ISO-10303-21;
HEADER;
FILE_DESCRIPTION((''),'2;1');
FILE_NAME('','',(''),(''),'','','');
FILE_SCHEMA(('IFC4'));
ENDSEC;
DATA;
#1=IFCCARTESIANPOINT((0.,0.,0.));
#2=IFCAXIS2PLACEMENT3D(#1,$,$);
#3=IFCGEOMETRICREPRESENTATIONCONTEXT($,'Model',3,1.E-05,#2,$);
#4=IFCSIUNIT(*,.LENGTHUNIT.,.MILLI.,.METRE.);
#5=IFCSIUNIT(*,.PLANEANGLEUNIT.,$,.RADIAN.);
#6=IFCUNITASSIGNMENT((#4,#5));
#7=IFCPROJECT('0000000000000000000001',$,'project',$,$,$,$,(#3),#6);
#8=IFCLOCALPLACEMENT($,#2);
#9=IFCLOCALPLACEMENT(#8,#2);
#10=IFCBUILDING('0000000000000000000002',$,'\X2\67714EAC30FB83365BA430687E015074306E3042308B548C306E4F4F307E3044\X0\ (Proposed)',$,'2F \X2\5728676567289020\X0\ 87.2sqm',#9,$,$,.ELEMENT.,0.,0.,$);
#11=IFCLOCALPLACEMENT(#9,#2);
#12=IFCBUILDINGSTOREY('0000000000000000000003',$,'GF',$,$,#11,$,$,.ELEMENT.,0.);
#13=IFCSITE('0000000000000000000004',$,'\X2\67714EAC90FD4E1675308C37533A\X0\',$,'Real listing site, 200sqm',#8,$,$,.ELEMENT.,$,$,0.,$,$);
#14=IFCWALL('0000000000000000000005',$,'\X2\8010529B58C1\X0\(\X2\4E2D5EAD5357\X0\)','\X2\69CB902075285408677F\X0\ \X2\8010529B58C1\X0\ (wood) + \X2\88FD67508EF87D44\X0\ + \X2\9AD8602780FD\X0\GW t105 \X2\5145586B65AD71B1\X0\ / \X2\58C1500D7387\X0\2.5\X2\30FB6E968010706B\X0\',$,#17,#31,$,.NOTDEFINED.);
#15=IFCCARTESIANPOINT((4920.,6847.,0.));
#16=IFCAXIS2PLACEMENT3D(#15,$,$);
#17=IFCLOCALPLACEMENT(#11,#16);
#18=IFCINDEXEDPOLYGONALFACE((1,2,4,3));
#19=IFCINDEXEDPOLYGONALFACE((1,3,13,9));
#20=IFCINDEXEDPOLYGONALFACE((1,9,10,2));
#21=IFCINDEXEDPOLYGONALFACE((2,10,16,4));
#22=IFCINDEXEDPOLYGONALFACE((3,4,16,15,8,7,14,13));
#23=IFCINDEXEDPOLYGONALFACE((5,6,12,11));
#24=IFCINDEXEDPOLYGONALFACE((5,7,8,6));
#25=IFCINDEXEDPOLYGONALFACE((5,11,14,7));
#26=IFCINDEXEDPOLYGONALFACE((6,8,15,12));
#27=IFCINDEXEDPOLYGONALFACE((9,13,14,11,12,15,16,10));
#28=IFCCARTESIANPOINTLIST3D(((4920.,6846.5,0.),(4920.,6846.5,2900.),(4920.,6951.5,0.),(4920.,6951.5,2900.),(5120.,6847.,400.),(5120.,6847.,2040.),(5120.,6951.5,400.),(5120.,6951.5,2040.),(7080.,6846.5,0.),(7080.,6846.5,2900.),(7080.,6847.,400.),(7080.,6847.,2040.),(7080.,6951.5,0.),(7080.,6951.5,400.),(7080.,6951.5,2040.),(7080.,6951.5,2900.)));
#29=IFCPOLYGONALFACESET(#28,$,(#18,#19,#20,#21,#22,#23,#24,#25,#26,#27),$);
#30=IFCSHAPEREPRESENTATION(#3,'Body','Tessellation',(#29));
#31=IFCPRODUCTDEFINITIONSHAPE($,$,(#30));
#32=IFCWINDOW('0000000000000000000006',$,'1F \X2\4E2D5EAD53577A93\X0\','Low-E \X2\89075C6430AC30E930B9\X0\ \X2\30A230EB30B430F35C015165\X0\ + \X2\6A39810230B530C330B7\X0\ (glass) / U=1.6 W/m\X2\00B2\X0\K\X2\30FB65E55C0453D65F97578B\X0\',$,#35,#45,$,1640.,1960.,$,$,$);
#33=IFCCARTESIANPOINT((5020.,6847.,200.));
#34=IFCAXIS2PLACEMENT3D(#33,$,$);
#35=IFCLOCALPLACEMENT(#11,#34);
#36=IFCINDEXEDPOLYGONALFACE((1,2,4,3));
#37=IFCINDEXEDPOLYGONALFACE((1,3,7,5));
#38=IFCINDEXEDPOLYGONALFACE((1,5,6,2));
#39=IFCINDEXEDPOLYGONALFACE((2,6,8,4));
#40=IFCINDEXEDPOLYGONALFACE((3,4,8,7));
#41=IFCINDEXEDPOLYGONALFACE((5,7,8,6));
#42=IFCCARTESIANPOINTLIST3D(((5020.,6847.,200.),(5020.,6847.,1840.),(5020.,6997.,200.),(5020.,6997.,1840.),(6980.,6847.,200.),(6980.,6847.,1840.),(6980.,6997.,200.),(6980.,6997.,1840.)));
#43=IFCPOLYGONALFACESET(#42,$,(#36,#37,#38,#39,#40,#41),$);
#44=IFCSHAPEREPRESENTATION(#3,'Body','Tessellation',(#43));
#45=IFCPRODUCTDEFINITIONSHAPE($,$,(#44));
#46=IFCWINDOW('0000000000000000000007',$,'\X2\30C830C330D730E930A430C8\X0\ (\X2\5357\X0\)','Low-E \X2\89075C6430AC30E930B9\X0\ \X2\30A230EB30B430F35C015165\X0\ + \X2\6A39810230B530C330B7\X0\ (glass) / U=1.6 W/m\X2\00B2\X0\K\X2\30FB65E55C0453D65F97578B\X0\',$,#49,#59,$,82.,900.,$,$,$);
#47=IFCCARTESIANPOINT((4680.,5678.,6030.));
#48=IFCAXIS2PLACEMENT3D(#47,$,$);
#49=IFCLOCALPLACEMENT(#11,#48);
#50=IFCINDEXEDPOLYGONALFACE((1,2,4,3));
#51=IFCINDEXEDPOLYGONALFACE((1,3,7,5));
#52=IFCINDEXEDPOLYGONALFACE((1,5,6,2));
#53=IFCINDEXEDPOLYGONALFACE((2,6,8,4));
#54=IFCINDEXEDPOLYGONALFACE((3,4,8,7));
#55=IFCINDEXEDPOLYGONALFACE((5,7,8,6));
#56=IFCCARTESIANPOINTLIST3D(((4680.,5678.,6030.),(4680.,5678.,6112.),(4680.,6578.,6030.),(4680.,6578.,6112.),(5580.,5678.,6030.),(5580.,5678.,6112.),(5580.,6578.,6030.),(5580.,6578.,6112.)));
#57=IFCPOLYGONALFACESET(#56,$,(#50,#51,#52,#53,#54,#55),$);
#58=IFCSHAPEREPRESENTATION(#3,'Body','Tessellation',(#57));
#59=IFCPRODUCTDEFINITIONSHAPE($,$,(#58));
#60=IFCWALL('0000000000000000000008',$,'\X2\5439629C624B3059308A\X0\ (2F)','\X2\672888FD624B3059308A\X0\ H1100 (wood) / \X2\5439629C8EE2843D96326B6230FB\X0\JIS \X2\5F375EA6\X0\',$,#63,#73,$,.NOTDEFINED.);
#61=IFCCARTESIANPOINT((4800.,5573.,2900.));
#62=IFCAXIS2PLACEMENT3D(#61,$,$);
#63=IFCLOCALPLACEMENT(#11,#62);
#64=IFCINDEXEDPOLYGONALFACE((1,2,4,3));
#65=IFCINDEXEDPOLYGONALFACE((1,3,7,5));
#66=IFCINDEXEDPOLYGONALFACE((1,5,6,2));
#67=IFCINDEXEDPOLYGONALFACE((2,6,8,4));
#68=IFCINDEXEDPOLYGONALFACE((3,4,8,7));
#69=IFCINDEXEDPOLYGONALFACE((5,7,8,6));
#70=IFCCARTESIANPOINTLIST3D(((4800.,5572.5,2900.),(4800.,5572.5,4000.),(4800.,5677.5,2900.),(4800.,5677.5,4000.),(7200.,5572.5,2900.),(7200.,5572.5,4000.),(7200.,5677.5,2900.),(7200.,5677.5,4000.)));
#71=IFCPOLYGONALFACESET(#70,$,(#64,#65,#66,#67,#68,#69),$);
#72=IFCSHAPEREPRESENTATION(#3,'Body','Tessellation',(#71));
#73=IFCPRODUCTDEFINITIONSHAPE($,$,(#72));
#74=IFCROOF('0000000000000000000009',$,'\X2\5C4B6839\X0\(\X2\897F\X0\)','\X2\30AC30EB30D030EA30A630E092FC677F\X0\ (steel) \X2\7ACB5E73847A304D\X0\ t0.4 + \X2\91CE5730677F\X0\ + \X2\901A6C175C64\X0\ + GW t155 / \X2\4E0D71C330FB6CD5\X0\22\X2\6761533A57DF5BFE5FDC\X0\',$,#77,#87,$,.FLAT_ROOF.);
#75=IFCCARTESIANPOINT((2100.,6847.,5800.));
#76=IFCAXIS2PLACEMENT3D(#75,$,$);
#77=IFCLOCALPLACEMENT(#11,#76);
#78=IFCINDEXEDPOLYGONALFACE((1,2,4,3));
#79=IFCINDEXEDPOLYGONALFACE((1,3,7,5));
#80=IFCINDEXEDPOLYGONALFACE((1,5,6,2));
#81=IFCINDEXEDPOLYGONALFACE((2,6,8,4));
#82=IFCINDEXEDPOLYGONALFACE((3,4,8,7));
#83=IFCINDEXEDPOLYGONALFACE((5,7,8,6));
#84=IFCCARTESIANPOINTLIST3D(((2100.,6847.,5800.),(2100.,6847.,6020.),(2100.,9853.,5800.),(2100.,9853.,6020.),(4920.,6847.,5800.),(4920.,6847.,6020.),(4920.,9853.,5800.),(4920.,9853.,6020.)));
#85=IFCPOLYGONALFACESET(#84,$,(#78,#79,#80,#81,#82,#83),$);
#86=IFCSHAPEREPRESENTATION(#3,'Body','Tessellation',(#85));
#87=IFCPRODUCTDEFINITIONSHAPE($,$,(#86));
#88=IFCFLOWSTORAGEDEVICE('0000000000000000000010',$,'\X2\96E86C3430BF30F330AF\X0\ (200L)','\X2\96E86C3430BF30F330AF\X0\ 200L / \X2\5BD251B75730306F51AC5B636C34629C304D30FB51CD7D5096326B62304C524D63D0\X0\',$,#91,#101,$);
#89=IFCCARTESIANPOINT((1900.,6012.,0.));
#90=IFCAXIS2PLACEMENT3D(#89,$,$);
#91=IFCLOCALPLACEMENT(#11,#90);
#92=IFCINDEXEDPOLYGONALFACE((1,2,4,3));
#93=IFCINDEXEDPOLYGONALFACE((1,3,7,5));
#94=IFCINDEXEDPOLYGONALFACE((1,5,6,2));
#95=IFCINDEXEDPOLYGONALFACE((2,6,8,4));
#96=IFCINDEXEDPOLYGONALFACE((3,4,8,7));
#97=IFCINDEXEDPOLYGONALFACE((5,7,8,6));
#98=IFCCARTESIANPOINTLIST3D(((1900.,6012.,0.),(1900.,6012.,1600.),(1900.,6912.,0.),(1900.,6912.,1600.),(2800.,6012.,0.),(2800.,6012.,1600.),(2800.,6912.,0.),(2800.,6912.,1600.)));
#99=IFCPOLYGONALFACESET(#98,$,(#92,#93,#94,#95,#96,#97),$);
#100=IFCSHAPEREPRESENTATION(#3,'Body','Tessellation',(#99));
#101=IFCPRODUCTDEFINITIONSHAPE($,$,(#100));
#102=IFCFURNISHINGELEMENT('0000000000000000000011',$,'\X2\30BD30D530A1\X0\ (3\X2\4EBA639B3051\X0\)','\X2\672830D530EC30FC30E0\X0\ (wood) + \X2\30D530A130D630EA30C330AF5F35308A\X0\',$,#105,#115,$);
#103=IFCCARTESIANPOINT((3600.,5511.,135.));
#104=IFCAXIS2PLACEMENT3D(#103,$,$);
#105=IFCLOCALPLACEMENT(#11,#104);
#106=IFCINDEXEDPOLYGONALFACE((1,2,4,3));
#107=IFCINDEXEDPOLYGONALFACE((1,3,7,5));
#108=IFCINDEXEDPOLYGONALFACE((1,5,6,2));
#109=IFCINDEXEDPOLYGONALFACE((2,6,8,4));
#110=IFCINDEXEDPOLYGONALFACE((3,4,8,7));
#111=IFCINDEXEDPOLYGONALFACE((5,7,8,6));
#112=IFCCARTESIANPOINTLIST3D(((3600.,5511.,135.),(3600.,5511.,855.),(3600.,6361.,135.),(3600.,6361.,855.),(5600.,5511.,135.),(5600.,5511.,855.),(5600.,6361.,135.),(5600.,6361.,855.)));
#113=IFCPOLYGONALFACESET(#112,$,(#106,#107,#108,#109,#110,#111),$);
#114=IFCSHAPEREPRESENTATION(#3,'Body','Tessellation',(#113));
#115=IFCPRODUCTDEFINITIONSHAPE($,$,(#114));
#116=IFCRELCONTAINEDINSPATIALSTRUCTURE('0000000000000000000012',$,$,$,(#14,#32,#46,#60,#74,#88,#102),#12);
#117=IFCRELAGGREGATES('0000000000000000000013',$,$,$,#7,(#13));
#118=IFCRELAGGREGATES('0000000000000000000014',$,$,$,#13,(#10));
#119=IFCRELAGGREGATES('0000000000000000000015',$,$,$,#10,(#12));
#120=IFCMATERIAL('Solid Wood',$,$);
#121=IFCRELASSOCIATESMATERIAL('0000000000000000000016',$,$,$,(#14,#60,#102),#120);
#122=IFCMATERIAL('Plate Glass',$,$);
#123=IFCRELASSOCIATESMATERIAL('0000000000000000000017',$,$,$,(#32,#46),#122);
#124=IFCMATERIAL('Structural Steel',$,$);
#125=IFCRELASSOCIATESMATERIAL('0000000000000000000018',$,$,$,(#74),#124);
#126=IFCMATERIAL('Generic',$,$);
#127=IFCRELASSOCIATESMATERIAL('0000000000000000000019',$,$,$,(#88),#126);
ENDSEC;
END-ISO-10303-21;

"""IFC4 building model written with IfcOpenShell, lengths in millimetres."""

from ifc_helpers import new_model, si_unit, frame, frame_2d, origin, place, context, project, spatial, rectangle, extrude, material, element, fill, save


model = new_model("IFC4")

# Units and contexts
model_context = context("Model", 3, precision=1e-05, world=origin())
ifc_project = project(units=[si_unit("LENGTHUNIT", "METRE", prefix="MILLI"), si_unit("PLANEANGLEUNIT", "RADIAN")], contexts=[model_context])

# Site, building, storey
site_placement = place(None, origin())
site = spatial("IfcSite", under=ifc_project, at=site_placement, Name="東京都世田谷区", ObjectType="Real listing site, 200sqm", CompositionType="ELEMENT", RefElevation=0.0)
building_placement = place(site_placement, origin())
building = spatial("IfcBuilding", under=site, at=building_placement, Name="東京・茶室と縁側のある和の住まい (Proposed)", ObjectType="2F 在来木造 87.2sqm", CompositionType="ELEMENT", ElevationOfRefHeight=0.0, ElevationOfTerrain=0.0)
storey_placement = place(building_placement, origin())
storey = spatial("IfcBuildingStorey", under=building, at=storey_placement, Name="GF", CompositionType="ELEMENT", Elevation=0.0)

# Shared definitions
ifc_material_1 = material(Name="Solid Wood")

# Wall, opening, window
wall_1_placement = place(storey_placement, frame((4920.0, 6847.0, 0.0)))
wall_1 = element("IfcWall", 1, at=wall_1_placement, inside=storey, material=ifc_material_1, Name="耐力壁(中庭南)", Description="構造用合板 耐力壁 (wood) + 製材軸組 + 高性能GW t105 充填断熱 / 壁倍率2.5・準耐火", PredefinedType="NOTDEFINED", context=model_context, shape_type="SweptSolid", body=[
    extrude(rectangle(XDim=2160.0, YDim=105.0, at=frame_2d((1080.0, 52.0))), frame((4920.0, 6847.0, 0.0)), (0.0, 0.0, 1.0), 2900.0),
])
opening_placement = place(storey_placement, frame((5020.0, 6847.0, 200.0)))
opening = element("IfcOpeningElement", 2, at=opening_placement, cuts=wall_1, PredefinedType="NOTDEFINED", context=model_context, shape_type="SweptSolid", body=[
    extrude(rectangle(XDim=1960.0, YDim=150.0, at=frame_2d((980.0, 75.0))), frame((5020.0, 6847.0, 200.0)), (0.0, 0.0, 1.0), 1640.0),
])
ifc_material_2 = material(Name="Plate Glass")
window_1_placement = place(storey_placement, frame((5020.0, 6847.0, 200.0)))
window_1 = element("IfcWindow", 3, at=window_1_placement, inside=storey, material=ifc_material_2, Name="1F 中庭南窓", Description="Low-E 複層ガラス アルゴン封入 + 樹脂サッシ (glass) / U=1.6 W/m²K・日射取得型", OverallHeight=1640.0, OverallWidth=1960.0, context=model_context, shape_type="SweptSolid", body=[
    extrude(rectangle(XDim=1960.0, YDim=150.0, at=frame_2d((980.0, 75.0))), frame((5020.0, 6847.0, 200.0)), (0.0, 0.0, 1.0), 1640.0),
])
fill(opening, window_1)

# Window
window_2_placement = place(storey_placement, frame((4680.0, 5678.0, 6030.0)))
element("IfcWindow", 4, at=window_2_placement, inside=storey, material=ifc_material_2, Name="トップライト (南)", Description="Low-E 複層ガラス アルゴン封入 + 樹脂サッシ (glass) / U=1.6 W/m²K・日射取得型", OverallHeight=82.0, OverallWidth=900.0, context=model_context, shape_type="SweptSolid", body=[
    extrude(rectangle(XDim=900.0, YDim=900.0, at=frame_2d((450.0, 450.0))), frame((4680.0, 5678.0, 6030.0)), (0.0, 0.0, 1.0), 82.0),
])

# Wall
wall_2_placement = place(storey_placement, frame((4800.0, 5573.0, 2900.0)))
element("IfcWall", 5, at=wall_2_placement, inside=storey, material=ifc_material_1, Name="吹抜手すり (2F)", Description="木製手すり H1100 (wood) / 吹抜転落防止・JIS 強度", PredefinedType="NOTDEFINED", context=model_context, shape_type="SweptSolid", body=[
    extrude(rectangle(XDim=2400.0, YDim=105.0, at=frame_2d((1200.0, 52.0))), frame((4800.0, 5573.0, 2900.0)), (0.0, 0.0, 1.0), 1100.0),
])

# Roof
ifc_material_3 = material(Name="Structural Steel")
for number, where, name in (
    (6, (2100.0, 6847.0, 5800.0), "屋根(西)"),
):
    element("IfcRoof", number, at=place(storey_placement, frame(where)), inside=storey, material=ifc_material_3, Name=name, Description="ガルバリウム鋼板 (steel) 立平葺き t0.4 + 野地板 + 通気層 + GW t155 / 不燃・法22条区域対応", PredefinedType="FLAT_ROOF", context=model_context, shape_type="SweptSolid", body=[
        extrude(rectangle(XDim=2820.0, YDim=3006.0, at=frame_2d((1410.0, 1503.0))), frame((2100.0, 6847.0, 5800.0)), (0.0, 0.0, 1.0), 220.0),
    ])

# Flow storage device
ifc_material_4 = material(Name="Generic")
flow_storage_device_placement = place(storey_placement, frame((1900.0, 6012.0, 0.0)))
element("IfcFlowStorageDevice", 7, at=flow_storage_device_placement, inside=storey, material=ifc_material_4, Name="雨水タンク (200L)", Description="雨水タンク 200L / 寒冷地は冬季水抜き・凍結防止が前提", context=model_context, shape_type="SweptSolid", body=[
    extrude(rectangle(XDim=900.0, YDim=900.0, at=frame_2d((450.0, 450.0))), frame((1900.0, 6012.0, 0.0)), (0.0, 0.0, 1.0), 1600.0),
])

# Furnishing element
furnishing_placement = place(storey_placement, frame((3600.0, 5511.0, 135.0)))
element("IfcFurnishingElement", 8, at=furnishing_placement, inside=storey, material=ifc_material_1, Name="ソファ (3人掛け)", Description="木フレーム (wood) + ファブリック張り", context=model_context, shape_type="SweptSolid", body=[
    extrude(rectangle(XDim=2000.0, YDim=850.0, at=frame_2d((1000.0, 425.0))), frame((3600.0, 5511.0, 135.0)), (0.0, 0.0, 1.0), 720.0),
])

save(model, "model.ifc")
